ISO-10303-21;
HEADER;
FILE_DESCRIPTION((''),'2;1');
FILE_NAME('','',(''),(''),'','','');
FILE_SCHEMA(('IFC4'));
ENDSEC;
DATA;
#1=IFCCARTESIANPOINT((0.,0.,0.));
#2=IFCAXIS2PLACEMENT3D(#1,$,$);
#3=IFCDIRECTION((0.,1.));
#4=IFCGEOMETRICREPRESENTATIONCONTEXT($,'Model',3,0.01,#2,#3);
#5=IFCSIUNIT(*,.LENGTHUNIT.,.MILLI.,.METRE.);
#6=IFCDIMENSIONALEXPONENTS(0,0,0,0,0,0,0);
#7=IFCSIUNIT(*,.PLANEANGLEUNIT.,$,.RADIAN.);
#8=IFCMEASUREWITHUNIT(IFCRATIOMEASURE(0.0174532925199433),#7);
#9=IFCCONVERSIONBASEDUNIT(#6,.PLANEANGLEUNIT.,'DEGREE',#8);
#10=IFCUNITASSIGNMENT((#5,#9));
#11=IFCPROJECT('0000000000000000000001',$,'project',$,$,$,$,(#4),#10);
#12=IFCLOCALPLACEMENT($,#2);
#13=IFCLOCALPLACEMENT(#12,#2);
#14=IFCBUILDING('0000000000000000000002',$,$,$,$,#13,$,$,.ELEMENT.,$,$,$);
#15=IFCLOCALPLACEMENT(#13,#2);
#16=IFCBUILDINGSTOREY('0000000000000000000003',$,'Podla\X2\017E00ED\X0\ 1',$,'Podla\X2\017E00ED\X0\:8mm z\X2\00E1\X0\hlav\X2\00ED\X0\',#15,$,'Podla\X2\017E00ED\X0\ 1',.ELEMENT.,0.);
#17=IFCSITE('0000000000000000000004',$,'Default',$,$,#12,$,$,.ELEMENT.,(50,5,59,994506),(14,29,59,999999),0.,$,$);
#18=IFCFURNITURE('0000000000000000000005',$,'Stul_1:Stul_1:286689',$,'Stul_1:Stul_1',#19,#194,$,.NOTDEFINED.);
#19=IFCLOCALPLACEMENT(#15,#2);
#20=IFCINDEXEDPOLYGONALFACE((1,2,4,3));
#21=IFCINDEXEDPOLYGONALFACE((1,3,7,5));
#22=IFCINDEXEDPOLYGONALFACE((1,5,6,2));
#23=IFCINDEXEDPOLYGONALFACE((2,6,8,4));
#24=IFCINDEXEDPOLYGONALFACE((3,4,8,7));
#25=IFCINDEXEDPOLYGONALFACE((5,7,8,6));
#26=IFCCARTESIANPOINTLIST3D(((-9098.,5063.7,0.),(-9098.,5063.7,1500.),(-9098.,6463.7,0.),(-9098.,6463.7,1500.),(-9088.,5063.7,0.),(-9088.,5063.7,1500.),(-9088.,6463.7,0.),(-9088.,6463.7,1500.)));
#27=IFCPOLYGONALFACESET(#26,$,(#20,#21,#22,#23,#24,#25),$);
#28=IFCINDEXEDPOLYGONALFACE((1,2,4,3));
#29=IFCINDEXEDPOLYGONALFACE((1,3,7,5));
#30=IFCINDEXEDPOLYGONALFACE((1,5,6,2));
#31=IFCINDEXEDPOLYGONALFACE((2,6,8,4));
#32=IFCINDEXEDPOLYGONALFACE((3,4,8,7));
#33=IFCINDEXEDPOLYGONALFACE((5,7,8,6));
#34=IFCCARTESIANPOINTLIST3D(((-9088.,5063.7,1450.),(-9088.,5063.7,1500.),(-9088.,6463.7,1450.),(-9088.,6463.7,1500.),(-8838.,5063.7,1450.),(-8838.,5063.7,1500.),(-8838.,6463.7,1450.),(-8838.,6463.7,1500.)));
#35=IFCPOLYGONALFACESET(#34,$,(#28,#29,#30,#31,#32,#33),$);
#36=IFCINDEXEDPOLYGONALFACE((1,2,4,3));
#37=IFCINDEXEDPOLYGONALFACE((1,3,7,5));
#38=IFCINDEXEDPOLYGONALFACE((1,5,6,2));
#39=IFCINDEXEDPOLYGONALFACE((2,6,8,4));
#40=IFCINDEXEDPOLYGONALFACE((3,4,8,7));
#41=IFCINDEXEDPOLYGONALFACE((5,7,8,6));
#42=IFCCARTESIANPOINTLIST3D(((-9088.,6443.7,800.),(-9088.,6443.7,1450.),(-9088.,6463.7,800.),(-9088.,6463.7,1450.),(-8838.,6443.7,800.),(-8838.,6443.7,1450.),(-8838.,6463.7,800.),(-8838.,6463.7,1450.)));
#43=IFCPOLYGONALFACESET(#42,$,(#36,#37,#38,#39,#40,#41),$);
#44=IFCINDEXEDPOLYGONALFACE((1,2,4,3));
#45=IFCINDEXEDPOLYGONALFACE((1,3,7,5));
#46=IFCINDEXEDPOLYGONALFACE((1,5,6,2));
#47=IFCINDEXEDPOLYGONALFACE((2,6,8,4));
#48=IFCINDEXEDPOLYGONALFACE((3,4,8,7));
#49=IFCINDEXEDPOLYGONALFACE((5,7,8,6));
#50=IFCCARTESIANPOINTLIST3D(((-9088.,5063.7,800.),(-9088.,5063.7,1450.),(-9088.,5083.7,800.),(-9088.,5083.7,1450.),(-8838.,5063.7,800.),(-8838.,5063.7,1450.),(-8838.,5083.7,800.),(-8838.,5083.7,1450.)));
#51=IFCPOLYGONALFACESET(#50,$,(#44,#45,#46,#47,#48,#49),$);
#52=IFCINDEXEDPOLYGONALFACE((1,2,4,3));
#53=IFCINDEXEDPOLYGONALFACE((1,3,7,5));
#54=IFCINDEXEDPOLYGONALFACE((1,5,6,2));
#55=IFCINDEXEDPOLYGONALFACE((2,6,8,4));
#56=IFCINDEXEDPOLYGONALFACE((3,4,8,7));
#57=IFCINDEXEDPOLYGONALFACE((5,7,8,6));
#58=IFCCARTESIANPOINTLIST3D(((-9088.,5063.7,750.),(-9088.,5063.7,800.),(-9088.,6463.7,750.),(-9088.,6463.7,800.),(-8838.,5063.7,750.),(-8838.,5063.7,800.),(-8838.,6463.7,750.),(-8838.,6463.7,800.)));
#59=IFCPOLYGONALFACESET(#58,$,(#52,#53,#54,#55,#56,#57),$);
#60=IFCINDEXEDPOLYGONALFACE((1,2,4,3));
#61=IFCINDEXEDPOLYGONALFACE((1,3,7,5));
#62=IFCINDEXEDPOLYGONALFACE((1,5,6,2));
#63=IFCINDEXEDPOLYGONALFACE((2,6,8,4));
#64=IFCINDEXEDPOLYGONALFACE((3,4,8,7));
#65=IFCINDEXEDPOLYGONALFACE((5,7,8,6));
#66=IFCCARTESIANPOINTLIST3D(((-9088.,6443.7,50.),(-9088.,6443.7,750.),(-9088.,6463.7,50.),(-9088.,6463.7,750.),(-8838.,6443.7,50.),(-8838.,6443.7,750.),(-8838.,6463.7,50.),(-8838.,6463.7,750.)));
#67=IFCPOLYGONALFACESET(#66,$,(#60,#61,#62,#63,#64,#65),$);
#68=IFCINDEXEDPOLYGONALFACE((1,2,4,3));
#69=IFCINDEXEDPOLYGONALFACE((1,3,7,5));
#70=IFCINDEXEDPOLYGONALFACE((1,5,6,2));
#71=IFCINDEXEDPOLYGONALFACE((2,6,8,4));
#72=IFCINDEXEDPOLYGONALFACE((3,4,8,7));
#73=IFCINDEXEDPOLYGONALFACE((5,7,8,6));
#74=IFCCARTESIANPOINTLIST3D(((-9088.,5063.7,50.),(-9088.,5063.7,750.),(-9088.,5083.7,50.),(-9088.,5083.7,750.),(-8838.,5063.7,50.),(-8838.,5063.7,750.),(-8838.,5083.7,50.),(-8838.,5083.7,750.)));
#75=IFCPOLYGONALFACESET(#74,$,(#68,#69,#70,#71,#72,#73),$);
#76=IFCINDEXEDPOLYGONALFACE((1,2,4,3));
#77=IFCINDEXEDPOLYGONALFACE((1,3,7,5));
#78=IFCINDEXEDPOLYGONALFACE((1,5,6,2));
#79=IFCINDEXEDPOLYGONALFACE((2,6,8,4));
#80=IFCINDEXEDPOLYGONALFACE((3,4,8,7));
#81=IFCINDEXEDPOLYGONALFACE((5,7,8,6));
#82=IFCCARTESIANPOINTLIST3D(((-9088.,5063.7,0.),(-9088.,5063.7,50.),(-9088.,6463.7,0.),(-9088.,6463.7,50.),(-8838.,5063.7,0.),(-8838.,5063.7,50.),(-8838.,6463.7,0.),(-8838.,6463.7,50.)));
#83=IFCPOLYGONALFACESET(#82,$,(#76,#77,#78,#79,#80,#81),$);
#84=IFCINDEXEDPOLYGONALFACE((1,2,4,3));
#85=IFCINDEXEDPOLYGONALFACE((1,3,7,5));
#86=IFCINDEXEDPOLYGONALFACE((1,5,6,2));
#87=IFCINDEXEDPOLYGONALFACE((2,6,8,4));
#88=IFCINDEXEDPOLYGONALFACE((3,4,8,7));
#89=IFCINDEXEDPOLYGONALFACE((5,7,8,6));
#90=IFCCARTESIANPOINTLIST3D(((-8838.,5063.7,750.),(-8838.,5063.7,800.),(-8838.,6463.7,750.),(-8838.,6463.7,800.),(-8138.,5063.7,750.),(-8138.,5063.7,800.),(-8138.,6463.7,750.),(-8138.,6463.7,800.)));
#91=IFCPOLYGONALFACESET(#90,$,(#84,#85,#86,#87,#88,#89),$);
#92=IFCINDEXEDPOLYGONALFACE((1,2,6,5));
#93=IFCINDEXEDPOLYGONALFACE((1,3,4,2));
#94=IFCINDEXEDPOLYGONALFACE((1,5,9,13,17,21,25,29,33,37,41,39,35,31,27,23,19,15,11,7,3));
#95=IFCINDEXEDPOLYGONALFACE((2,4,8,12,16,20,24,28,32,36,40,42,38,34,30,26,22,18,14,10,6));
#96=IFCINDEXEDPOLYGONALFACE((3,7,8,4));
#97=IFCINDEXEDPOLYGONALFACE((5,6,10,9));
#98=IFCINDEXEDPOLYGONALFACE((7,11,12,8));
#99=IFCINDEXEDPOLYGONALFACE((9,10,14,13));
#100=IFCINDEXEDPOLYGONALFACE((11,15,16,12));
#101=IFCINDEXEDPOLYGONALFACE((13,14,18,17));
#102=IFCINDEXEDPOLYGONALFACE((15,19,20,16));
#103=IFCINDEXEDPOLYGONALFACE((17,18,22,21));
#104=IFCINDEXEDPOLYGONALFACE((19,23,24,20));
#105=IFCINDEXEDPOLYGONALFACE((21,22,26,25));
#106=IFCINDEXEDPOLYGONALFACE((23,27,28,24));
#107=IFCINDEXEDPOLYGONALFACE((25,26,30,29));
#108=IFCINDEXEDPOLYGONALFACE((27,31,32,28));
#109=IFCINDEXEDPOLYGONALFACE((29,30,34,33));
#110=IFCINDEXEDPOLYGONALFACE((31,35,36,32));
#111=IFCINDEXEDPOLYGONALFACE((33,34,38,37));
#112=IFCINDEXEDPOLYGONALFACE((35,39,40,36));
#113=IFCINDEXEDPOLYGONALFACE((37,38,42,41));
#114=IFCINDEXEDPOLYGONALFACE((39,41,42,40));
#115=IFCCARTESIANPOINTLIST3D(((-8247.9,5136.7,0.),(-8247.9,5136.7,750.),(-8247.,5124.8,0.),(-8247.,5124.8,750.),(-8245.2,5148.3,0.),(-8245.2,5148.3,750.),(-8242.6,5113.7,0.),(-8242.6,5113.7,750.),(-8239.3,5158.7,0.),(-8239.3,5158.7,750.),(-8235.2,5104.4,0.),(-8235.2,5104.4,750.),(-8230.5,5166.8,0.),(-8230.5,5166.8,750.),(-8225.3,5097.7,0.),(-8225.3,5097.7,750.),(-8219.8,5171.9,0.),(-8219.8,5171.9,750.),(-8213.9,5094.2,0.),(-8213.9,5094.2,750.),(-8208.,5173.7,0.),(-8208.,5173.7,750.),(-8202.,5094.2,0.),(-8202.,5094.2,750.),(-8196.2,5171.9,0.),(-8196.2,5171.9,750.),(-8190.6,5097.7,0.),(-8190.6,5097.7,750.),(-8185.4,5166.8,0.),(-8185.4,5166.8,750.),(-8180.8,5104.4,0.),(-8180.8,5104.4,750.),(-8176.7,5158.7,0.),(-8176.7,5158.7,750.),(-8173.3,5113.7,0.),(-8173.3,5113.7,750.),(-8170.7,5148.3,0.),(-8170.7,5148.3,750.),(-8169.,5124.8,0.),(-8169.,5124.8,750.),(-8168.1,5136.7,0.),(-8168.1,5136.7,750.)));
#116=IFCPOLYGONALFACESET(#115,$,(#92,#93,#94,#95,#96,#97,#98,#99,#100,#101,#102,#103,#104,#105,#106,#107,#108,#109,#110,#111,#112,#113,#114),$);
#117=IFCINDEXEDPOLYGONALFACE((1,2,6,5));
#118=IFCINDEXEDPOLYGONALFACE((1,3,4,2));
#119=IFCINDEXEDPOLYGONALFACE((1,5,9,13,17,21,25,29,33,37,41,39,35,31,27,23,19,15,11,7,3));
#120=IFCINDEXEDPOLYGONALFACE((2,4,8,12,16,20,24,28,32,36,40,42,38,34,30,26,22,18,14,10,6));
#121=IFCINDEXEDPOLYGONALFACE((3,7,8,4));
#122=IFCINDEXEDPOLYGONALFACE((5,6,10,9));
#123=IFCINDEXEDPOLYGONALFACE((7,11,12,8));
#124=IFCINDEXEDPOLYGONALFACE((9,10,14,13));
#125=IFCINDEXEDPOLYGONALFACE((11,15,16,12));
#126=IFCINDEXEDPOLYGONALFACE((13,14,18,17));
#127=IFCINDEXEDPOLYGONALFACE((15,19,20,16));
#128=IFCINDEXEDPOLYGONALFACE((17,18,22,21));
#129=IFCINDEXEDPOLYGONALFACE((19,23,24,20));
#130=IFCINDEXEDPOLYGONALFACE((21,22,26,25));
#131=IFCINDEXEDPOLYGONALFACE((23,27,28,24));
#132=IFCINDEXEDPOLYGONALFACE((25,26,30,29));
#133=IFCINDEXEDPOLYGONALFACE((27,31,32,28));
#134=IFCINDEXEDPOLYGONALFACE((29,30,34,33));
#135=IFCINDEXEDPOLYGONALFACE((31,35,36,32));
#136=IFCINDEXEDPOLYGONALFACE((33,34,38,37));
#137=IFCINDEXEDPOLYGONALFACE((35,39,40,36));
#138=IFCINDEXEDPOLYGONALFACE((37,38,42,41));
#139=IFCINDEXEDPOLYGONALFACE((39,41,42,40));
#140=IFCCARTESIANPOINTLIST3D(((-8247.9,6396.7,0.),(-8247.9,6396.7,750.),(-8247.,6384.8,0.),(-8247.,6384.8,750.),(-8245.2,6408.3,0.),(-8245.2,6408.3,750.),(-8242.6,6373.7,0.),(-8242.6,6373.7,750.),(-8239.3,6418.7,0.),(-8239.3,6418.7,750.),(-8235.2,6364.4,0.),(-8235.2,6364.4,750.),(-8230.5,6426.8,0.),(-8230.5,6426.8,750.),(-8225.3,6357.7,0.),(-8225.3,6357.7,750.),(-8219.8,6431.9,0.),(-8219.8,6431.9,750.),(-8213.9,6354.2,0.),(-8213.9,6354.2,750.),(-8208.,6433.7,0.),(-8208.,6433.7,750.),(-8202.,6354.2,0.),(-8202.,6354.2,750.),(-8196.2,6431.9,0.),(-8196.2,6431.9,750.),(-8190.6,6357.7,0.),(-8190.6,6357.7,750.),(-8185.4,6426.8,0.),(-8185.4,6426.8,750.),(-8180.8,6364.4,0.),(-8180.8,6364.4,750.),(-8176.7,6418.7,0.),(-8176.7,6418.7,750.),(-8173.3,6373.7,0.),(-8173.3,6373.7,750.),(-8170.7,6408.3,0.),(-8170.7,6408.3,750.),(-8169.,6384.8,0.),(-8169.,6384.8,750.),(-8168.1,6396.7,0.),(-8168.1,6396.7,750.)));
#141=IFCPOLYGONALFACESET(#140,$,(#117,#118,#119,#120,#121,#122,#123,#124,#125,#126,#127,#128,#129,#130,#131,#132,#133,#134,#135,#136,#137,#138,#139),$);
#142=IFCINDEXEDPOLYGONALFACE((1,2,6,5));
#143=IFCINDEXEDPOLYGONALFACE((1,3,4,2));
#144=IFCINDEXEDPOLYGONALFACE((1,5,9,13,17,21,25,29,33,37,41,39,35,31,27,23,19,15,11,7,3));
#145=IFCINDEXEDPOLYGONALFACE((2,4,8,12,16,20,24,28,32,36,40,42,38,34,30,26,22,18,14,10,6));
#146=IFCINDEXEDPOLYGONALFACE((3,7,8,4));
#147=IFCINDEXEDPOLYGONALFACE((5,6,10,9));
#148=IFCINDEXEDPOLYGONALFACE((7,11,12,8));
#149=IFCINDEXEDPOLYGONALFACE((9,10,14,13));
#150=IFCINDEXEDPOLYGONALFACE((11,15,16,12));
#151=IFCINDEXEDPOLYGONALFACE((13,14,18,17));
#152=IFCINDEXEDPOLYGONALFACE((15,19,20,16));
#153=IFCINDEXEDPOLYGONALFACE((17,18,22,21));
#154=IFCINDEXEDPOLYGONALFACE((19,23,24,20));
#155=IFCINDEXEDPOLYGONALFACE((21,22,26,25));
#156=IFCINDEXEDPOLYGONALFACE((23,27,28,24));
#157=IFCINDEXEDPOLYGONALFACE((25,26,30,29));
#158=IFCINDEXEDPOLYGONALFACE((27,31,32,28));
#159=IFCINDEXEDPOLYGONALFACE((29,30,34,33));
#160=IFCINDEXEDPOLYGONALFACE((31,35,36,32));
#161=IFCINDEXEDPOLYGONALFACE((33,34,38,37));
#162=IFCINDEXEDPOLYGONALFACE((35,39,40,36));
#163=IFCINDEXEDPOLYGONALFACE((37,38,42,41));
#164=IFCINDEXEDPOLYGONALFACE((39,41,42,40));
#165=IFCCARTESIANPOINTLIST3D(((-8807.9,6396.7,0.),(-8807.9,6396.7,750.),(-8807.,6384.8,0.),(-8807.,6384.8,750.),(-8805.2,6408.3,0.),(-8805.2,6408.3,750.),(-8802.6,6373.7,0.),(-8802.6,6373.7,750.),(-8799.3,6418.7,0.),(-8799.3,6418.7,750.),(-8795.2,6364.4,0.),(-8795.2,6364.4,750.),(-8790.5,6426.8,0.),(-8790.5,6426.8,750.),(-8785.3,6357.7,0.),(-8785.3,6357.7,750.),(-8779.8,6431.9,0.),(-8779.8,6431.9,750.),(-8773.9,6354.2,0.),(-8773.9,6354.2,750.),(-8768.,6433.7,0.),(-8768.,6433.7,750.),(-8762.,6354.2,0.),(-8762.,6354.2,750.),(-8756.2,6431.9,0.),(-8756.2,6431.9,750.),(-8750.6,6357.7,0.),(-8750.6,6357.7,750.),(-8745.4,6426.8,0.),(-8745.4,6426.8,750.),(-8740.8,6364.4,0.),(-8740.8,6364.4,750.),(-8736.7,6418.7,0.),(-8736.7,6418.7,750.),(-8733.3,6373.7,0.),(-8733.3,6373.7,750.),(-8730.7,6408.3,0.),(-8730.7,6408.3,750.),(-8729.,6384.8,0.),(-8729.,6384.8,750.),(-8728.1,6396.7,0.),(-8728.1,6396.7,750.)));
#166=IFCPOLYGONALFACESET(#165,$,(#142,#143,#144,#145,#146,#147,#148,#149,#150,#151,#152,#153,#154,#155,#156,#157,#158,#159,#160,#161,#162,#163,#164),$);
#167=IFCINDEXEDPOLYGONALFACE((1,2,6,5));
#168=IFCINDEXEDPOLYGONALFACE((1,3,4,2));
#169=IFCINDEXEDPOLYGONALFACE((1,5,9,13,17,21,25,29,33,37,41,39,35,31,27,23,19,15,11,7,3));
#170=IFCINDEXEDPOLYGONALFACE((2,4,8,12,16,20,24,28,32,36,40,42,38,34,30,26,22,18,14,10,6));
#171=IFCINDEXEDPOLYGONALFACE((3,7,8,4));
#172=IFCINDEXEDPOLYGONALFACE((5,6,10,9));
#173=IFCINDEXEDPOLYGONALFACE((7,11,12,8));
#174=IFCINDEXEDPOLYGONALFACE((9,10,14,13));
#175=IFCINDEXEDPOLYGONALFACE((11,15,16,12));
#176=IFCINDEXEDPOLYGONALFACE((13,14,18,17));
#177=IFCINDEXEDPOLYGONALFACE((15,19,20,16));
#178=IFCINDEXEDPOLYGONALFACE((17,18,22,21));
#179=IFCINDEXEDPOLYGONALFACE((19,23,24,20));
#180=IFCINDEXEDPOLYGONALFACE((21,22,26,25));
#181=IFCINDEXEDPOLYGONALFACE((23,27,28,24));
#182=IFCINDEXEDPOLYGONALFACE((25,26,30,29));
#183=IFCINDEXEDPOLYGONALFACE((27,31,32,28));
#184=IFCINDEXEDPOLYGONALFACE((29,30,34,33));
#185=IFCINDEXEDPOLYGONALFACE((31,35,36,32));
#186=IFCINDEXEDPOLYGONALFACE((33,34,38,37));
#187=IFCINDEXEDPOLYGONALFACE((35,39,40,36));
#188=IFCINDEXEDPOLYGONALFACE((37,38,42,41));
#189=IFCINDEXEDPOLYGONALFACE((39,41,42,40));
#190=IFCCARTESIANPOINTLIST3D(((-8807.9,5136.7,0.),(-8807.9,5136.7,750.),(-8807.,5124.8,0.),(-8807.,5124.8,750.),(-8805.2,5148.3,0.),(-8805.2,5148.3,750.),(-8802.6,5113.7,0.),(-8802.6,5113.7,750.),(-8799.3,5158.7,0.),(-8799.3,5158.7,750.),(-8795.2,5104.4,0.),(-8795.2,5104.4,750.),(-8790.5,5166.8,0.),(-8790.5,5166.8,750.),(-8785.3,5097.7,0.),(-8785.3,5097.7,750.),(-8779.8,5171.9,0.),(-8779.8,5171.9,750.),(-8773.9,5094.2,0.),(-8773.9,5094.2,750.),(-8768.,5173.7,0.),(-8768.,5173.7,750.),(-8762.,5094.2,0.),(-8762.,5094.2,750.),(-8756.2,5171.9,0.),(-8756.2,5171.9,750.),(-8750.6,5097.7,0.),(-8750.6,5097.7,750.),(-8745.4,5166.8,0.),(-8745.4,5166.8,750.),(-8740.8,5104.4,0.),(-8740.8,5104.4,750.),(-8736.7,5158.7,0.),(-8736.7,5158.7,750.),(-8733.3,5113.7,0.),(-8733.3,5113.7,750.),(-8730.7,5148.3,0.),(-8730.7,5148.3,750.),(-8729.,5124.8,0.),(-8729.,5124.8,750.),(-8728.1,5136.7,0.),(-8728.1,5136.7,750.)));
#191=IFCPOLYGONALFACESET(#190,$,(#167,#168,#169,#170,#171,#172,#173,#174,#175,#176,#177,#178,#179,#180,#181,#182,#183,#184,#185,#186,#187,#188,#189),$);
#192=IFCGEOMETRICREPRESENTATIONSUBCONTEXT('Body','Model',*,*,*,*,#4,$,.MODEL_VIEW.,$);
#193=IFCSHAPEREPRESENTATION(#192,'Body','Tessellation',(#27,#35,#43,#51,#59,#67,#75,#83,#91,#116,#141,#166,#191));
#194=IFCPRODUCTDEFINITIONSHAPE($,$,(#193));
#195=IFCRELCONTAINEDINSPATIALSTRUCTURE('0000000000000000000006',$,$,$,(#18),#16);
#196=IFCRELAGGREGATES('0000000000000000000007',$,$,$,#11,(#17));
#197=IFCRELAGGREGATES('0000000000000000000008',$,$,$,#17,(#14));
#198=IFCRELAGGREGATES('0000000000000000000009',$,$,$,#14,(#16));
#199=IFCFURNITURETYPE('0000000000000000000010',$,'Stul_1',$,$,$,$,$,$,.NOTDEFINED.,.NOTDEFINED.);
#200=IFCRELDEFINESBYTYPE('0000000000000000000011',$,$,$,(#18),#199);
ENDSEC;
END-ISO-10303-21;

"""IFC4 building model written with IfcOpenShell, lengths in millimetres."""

from ifc_helpers import new_model, entity, si_unit, converted_unit, direction, frame, frame_2d, origin, origin_2d_with_axis, place, context, subcontext, project, spatial, rectangle, circle, extrude, source, transform, mapped, type_object, type_shapes, element, save


model = new_model("IFC4")

# Units and contexts
model_context = context("Model", 3, precision=0.01, world=origin(), true_north=direction((0.0, 1.0)))
body_context = subcontext(model_context, "Body", "Model", "MODEL_VIEW")
ifc_project = project(units=[si_unit("LENGTHUNIT", "METRE", prefix="MILLI"), converted_unit("PLANEANGLEUNIT", "DEGREE", entity("IfcRatioMeasure", 0.0174532925199433), si_unit("PLANEANGLEUNIT", "RADIAN"), dimensions=[0, 0, 0, 0, 0, 0, 0])], contexts=[model_context])

# Site, building, storey
site_placement = place(None, origin())
site = spatial("IfcSite", under=ifc_project, at=site_placement, Name="Default", CompositionType="ELEMENT", RefLatitude=(50, 5, 59, 994506), RefLongitude=(14, 29, 59, 999999), RefElevation=0.0)
building_placement = place(site_placement, origin())
building = spatial("IfcBuilding", under=site, at=building_placement, CompositionType="ELEMENT")
storey_placement = place(building_placement, origin())
storey = spatial("IfcBuildingStorey", under=building, at=storey_placement, Name="Podlaží 1", ObjectType="Podlaží:8mm záhlaví", LongName="Podlaží 1", CompositionType="ELEMENT", Elevation=0.0)

# Furniture
furniture_type = type_object("IfcFurnitureType", Name="Stul_1", AssemblyPlace="NOTDEFINED", PredefinedType="NOTDEFINED")
shared_shape_1 = source(origin(), body_context, "Body", "SweptSolid", [
    extrude(rectangle(XDim=1400.0, YDim=10.0, at=origin_2d_with_axis()), frame((0.0, 605.0, 0.0), z_axis=(0.0, 0.0, 1.0), x_axis=(-1.0, 0.0, 0.0)), (0.0, 0.0, 1.0), 1500.0),
    extrude(rectangle(XDim=1400.0, YDim=250.0, at=frame_2d((0.0, 0.0), x_axis=(1.0, 0.0))), frame((0.0, 475.0, 1450.0), z_axis=(0.0, 0.0, 1.0), x_axis=(-1.0, 0.0, 0.0)), (0.0, 0.0, 1.0), 50.0),
    extrude(rectangle(XDim=20.0, YDim=250.0, at=origin_2d_with_axis()), frame((690.0, 475.0, 800.0), z_axis=(0.0, 0.0, 1.0), x_axis=(-1.0, 0.0, 0.0)), (0.0, 0.0, 1.0), 650.0),
    extrude(rectangle(XDim=20.0, YDim=250.0, at=frame_2d((0.0, 0.0), x_axis=(1.0, 0.0))), frame((-690.0, 475.0, 800.0), z_axis=(0.0, 0.0, 1.0), x_axis=(-1.0, 0.0, 0.0)), (0.0, 0.0, 1.0), 650.0),
    extrude(rectangle(XDim=1400.0, YDim=250.0, at=origin_2d_with_axis()), frame((0.0, 475.0, 750.0), z_axis=(0.0, 0.0, 1.0), x_axis=(-1.0, 0.0, 0.0)), (0.0, 0.0, 1.0), 50.0),
    extrude(rectangle(XDim=20.0, YDim=250.0, at=origin_2d_with_axis()), frame((690.0, 475.0, 50.0), z_axis=(0.0, 0.0, 1.0), x_axis=(-1.0, 0.0, 0.0)), (0.0, 0.0, 1.0), 700.0),
    extrude(rectangle(XDim=20.0, YDim=250.0, at=frame_2d((0.0, 0.0), x_axis=(1.0, 0.0))), frame((-690.0, 475.0, 50.0), z_axis=(0.0, 0.0, 1.0), x_axis=(-1.0, 0.0, 0.0)), (0.0, 0.0, 1.0), 700.0),
    extrude(rectangle(XDim=1400.0, YDim=250.0, at=origin_2d_with_axis()), frame((0.0, 475.0, 0.0), z_axis=(0.0, 0.0, 1.0), x_axis=(-1.0, 0.0, 0.0)), (0.0, 0.0, 1.0), 50.0),
    extrude(rectangle(XDim=1400.0, YDim=700.0, at=origin_2d_with_axis()), frame((0.0, 0.0, 750.0), z_axis=(0.0, 0.0, 1.0), x_axis=(-1.0, 0.0, 0.0)), (0.0, 0.0, 1.0), 50.0),
    extrude(circle(Radius=40.0, at=frame_2d((0.0, 0.0), x_axis=(1.0, 0.0))), frame((-630.0, -280.0, 0.0)), (0.0, 0.0, 1.0), 750.0),
    extrude(circle(Radius=40.0, at=frame_2d((0.0, 0.0), x_axis=(1.0, 0.0))), frame((630.0, -280.0, 0.0)), (0.0, 0.0, 1.0), 750.0),
    extrude(circle(Radius=40.0, at=frame_2d((0.0, 0.0), x_axis=(1.0, 0.0))), frame((630.0, 280.0, 0.0)), (0.0, 0.0, 1.0), 750.0),
    extrude(circle(Radius=40.0, at=frame_2d((0.0, 0.0), x_axis=(1.0, 0.0))), frame((-630.0, 280.0, 0.0)), (0.0, 0.0, 1.0), 750.0),
])
type_shapes(furniture_type, [shared_shape_1])
for number, where, z_axis, x_axis, name in (
    (1, (-8488.0, 5763.7, 0.0), (0.0, 0.0, 1.0), (0.0, 1.0, 0.0), "Stul_1:Stul_1:286689"),
):
    element("IfcFurniture", number, at=place(storey_placement, frame(where, z_axis=z_axis, x_axis=x_axis)), inside=storey, type_object=furniture_type, Name=name, ObjectType="Stul_1:Stul_1", PredefinedType="NOTDEFINED", context=body_context, shape_type="MappedRepresentation", body=[
        mapped(shared_shape_1, transform((0.0, 0.0, 0.0), scale=1.0)),
    ])

save(model, "model.ifc")
